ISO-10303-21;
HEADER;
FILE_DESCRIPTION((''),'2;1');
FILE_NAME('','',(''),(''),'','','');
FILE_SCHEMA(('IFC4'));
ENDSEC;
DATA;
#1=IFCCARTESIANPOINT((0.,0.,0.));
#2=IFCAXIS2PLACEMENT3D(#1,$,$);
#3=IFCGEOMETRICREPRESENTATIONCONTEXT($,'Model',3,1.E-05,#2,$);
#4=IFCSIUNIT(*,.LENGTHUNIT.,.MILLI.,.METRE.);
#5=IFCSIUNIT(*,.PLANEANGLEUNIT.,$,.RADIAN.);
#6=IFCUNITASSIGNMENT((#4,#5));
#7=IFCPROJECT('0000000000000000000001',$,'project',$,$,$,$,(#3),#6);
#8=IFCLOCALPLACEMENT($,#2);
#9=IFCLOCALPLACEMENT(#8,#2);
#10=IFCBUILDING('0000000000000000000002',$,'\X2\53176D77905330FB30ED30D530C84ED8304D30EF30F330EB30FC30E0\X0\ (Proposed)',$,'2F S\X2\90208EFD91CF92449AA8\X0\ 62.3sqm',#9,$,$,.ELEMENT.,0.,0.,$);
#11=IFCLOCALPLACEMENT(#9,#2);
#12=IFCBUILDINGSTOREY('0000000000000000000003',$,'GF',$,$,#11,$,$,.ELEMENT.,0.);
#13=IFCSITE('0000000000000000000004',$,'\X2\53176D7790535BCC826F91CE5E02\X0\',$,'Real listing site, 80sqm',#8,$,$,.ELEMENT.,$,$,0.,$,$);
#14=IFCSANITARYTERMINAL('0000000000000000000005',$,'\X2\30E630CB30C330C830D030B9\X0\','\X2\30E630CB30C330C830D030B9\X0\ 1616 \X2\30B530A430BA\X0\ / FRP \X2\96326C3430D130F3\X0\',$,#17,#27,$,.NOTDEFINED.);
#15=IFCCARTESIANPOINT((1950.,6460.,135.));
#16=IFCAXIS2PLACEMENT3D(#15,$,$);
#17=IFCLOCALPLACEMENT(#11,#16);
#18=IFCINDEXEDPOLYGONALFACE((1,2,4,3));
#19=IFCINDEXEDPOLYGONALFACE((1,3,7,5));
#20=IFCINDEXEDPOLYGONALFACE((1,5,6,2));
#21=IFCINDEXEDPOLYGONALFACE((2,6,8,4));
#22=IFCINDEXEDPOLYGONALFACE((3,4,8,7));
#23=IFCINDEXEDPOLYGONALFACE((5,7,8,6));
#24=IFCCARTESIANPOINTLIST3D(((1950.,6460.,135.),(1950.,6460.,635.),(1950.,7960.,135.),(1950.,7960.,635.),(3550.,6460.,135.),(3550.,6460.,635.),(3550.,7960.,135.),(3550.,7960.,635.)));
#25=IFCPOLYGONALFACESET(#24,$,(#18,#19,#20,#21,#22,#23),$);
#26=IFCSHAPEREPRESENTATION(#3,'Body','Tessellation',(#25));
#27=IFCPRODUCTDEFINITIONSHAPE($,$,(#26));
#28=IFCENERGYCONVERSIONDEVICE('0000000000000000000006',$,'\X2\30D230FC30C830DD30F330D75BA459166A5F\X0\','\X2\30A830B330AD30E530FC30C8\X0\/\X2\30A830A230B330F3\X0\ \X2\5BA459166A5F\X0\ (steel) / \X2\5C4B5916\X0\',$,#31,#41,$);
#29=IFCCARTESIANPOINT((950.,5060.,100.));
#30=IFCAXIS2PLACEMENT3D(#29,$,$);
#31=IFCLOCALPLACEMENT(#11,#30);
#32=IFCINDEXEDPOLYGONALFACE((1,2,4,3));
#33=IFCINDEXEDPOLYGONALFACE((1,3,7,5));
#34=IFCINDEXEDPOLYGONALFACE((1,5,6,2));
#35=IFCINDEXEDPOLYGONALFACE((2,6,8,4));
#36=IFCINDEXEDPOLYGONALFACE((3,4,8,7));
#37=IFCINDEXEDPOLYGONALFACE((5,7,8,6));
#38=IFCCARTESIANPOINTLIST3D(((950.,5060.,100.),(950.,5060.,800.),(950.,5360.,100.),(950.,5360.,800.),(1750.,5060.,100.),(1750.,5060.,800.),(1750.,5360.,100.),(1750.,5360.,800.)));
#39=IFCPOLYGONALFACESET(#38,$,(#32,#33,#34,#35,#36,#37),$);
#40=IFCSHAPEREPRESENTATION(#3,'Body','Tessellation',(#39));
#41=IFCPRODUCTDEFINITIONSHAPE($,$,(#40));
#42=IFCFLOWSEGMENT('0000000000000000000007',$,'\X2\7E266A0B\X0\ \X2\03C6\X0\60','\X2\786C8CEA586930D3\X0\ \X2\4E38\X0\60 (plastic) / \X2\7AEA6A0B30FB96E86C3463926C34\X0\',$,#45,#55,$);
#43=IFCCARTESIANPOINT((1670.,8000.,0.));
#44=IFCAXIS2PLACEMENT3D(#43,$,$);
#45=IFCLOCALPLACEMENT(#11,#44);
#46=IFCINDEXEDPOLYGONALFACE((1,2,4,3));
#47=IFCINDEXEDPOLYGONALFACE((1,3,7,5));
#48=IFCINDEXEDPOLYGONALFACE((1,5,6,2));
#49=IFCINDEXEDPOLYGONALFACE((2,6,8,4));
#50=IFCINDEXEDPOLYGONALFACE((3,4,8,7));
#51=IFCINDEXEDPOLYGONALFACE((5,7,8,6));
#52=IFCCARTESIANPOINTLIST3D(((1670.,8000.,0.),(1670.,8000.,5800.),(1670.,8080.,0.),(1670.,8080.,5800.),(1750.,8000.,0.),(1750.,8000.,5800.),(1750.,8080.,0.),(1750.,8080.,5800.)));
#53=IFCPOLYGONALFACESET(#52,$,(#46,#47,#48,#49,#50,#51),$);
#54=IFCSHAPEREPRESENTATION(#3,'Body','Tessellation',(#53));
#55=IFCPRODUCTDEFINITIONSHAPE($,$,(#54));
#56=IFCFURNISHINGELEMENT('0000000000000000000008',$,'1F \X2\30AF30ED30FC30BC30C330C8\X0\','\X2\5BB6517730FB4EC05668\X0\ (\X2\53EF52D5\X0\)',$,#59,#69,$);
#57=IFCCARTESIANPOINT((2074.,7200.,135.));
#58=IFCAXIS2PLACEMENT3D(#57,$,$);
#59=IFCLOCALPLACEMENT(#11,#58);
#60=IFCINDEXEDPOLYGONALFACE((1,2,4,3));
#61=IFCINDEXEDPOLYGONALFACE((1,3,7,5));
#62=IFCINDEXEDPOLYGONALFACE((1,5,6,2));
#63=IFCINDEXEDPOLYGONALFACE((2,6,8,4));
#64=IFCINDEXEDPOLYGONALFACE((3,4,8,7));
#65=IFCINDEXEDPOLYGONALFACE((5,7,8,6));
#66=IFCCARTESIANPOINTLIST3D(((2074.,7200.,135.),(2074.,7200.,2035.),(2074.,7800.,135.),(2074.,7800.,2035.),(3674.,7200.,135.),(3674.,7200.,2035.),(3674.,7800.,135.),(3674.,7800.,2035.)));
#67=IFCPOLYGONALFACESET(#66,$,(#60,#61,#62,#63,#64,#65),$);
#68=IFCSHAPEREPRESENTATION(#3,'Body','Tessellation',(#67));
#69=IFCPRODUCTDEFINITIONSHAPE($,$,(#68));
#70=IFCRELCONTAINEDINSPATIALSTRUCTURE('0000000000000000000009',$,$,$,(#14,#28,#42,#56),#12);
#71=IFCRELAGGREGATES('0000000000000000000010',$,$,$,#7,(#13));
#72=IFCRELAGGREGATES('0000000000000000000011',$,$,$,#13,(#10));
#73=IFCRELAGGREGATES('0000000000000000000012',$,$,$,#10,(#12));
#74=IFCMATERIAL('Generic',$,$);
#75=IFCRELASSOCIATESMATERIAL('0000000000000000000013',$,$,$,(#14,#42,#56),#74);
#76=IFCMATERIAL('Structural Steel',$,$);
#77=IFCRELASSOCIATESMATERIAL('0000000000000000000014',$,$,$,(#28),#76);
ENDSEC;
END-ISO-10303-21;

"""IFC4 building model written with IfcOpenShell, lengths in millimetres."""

from ifc_helpers import new_model, si_unit, frame, frame_2d, origin, place, context, project, spatial, rectangle, extrude, material, element, save


model = new_model("IFC4")

# Units and contexts
model_context = context("Model", 3, precision=1e-05, world=origin())
ifc_project = project(units=[si_unit("LENGTHUNIT", "METRE", prefix="MILLI"), si_unit("PLANEANGLEUNIT", "RADIAN")], contexts=[model_context])

# Site, building, storey
site_placement = place(None, origin())
site = spatial("IfcSite", under=ifc_project, at=site_placement, Name="北海道富良野市", ObjectType="Real listing site, 80sqm", CompositionType="ELEMENT", RefElevation=0.0)
building_placement = place(site_placement, origin())
building = spatial("IfcBuilding", under=site, at=building_placement, Name="北海道・ロフト付きワンルーム (Proposed)", ObjectType="2F S造軽量鉄骨 62.3sqm", CompositionType="ELEMENT", ElevationOfRefHeight=0.0, ElevationOfTerrain=0.0)
storey_placement = place(building_placement, origin())
storey = spatial("IfcBuildingStorey", under=building, at=storey_placement, Name="GF", CompositionType="ELEMENT", Elevation=0.0)

# Shared definitions
ifc_material_1 = material(Name="Generic")

# Sanitary terminal
sanitary_terminal_placement = place(storey_placement, frame((1950.0, 6460.0, 135.0)))
element("IfcSanitaryTerminal", 1, at=sanitary_terminal_placement, inside=storey, material=ifc_material_1, Name="ユニットバス", Description="ユニットバス 1616 サイズ / FRP 防水パン", PredefinedType="NOTDEFINED", context=model_context, shape_type="SweptSolid", body=[
    extrude(rectangle(XDim=1600.0, YDim=1500.0, at=frame_2d((800.0, 750.0))), frame((1950.0, 6460.0, 135.0)), (0.0, 0.0, 1.0), 500.0),
])

# Energy conversion device
ifc_material_2 = material(Name="Structural Steel")
energy_conversion_device_placement = place(storey_placement, frame((950.0, 5060.0, 100.0)))
element("IfcEnergyConversionDevice", 2, at=energy_conversion_device_placement, inside=storey, material=ifc_material_2, Name="ヒートポンプ室外機", Description="エコキュート/エアコン 室外機 (steel) / 屋外", context=model_context, shape_type="SweptSolid", body=[
    extrude(rectangle(XDim=800.0, YDim=300.0, at=frame_2d((400.0, 150.0))), frame((950.0, 5060.0, 100.0)), (0.0, 0.0, 1.0), 700.0),
])

# Flow segment
flow_segment_placement = place(storey_placement, frame((1670.0, 8000.0, 0.0)))
element("IfcFlowSegment", 3, at=flow_segment_placement, inside=storey, material=ifc_material_1, Name="縦樋 φ60", Description="硬質塩ビ 丸60 (plastic) / 竪樋・雨水排水", context=model_context, shape_type="SweptSolid", body=[
    extrude(rectangle(XDim=80.0, YDim=80.0, at=frame_2d((40.0, 40.0))), frame((1670.0, 8000.0, 0.0)), (0.0, 0.0, 1.0), 5800.0),
])

# Furnishing element
furnishing_placement = place(storey_placement, frame((2074.0, 7200.0, 135.0)))
element("IfcFurnishingElement", 4, at=furnishing_placement, inside=storey, material=ifc_material_1, Name="1F クローゼット", Description="家具・什器 (可動)", context=model_context, shape_type="SweptSolid", body=[
    extrude(rectangle(XDim=1600.0, YDim=600.0, at=frame_2d((800.0, 300.0))), frame((2074.0, 7200.0, 135.0)), (0.0, 0.0, 1.0), 1900.0),
])

save(model, "model.ifc")
